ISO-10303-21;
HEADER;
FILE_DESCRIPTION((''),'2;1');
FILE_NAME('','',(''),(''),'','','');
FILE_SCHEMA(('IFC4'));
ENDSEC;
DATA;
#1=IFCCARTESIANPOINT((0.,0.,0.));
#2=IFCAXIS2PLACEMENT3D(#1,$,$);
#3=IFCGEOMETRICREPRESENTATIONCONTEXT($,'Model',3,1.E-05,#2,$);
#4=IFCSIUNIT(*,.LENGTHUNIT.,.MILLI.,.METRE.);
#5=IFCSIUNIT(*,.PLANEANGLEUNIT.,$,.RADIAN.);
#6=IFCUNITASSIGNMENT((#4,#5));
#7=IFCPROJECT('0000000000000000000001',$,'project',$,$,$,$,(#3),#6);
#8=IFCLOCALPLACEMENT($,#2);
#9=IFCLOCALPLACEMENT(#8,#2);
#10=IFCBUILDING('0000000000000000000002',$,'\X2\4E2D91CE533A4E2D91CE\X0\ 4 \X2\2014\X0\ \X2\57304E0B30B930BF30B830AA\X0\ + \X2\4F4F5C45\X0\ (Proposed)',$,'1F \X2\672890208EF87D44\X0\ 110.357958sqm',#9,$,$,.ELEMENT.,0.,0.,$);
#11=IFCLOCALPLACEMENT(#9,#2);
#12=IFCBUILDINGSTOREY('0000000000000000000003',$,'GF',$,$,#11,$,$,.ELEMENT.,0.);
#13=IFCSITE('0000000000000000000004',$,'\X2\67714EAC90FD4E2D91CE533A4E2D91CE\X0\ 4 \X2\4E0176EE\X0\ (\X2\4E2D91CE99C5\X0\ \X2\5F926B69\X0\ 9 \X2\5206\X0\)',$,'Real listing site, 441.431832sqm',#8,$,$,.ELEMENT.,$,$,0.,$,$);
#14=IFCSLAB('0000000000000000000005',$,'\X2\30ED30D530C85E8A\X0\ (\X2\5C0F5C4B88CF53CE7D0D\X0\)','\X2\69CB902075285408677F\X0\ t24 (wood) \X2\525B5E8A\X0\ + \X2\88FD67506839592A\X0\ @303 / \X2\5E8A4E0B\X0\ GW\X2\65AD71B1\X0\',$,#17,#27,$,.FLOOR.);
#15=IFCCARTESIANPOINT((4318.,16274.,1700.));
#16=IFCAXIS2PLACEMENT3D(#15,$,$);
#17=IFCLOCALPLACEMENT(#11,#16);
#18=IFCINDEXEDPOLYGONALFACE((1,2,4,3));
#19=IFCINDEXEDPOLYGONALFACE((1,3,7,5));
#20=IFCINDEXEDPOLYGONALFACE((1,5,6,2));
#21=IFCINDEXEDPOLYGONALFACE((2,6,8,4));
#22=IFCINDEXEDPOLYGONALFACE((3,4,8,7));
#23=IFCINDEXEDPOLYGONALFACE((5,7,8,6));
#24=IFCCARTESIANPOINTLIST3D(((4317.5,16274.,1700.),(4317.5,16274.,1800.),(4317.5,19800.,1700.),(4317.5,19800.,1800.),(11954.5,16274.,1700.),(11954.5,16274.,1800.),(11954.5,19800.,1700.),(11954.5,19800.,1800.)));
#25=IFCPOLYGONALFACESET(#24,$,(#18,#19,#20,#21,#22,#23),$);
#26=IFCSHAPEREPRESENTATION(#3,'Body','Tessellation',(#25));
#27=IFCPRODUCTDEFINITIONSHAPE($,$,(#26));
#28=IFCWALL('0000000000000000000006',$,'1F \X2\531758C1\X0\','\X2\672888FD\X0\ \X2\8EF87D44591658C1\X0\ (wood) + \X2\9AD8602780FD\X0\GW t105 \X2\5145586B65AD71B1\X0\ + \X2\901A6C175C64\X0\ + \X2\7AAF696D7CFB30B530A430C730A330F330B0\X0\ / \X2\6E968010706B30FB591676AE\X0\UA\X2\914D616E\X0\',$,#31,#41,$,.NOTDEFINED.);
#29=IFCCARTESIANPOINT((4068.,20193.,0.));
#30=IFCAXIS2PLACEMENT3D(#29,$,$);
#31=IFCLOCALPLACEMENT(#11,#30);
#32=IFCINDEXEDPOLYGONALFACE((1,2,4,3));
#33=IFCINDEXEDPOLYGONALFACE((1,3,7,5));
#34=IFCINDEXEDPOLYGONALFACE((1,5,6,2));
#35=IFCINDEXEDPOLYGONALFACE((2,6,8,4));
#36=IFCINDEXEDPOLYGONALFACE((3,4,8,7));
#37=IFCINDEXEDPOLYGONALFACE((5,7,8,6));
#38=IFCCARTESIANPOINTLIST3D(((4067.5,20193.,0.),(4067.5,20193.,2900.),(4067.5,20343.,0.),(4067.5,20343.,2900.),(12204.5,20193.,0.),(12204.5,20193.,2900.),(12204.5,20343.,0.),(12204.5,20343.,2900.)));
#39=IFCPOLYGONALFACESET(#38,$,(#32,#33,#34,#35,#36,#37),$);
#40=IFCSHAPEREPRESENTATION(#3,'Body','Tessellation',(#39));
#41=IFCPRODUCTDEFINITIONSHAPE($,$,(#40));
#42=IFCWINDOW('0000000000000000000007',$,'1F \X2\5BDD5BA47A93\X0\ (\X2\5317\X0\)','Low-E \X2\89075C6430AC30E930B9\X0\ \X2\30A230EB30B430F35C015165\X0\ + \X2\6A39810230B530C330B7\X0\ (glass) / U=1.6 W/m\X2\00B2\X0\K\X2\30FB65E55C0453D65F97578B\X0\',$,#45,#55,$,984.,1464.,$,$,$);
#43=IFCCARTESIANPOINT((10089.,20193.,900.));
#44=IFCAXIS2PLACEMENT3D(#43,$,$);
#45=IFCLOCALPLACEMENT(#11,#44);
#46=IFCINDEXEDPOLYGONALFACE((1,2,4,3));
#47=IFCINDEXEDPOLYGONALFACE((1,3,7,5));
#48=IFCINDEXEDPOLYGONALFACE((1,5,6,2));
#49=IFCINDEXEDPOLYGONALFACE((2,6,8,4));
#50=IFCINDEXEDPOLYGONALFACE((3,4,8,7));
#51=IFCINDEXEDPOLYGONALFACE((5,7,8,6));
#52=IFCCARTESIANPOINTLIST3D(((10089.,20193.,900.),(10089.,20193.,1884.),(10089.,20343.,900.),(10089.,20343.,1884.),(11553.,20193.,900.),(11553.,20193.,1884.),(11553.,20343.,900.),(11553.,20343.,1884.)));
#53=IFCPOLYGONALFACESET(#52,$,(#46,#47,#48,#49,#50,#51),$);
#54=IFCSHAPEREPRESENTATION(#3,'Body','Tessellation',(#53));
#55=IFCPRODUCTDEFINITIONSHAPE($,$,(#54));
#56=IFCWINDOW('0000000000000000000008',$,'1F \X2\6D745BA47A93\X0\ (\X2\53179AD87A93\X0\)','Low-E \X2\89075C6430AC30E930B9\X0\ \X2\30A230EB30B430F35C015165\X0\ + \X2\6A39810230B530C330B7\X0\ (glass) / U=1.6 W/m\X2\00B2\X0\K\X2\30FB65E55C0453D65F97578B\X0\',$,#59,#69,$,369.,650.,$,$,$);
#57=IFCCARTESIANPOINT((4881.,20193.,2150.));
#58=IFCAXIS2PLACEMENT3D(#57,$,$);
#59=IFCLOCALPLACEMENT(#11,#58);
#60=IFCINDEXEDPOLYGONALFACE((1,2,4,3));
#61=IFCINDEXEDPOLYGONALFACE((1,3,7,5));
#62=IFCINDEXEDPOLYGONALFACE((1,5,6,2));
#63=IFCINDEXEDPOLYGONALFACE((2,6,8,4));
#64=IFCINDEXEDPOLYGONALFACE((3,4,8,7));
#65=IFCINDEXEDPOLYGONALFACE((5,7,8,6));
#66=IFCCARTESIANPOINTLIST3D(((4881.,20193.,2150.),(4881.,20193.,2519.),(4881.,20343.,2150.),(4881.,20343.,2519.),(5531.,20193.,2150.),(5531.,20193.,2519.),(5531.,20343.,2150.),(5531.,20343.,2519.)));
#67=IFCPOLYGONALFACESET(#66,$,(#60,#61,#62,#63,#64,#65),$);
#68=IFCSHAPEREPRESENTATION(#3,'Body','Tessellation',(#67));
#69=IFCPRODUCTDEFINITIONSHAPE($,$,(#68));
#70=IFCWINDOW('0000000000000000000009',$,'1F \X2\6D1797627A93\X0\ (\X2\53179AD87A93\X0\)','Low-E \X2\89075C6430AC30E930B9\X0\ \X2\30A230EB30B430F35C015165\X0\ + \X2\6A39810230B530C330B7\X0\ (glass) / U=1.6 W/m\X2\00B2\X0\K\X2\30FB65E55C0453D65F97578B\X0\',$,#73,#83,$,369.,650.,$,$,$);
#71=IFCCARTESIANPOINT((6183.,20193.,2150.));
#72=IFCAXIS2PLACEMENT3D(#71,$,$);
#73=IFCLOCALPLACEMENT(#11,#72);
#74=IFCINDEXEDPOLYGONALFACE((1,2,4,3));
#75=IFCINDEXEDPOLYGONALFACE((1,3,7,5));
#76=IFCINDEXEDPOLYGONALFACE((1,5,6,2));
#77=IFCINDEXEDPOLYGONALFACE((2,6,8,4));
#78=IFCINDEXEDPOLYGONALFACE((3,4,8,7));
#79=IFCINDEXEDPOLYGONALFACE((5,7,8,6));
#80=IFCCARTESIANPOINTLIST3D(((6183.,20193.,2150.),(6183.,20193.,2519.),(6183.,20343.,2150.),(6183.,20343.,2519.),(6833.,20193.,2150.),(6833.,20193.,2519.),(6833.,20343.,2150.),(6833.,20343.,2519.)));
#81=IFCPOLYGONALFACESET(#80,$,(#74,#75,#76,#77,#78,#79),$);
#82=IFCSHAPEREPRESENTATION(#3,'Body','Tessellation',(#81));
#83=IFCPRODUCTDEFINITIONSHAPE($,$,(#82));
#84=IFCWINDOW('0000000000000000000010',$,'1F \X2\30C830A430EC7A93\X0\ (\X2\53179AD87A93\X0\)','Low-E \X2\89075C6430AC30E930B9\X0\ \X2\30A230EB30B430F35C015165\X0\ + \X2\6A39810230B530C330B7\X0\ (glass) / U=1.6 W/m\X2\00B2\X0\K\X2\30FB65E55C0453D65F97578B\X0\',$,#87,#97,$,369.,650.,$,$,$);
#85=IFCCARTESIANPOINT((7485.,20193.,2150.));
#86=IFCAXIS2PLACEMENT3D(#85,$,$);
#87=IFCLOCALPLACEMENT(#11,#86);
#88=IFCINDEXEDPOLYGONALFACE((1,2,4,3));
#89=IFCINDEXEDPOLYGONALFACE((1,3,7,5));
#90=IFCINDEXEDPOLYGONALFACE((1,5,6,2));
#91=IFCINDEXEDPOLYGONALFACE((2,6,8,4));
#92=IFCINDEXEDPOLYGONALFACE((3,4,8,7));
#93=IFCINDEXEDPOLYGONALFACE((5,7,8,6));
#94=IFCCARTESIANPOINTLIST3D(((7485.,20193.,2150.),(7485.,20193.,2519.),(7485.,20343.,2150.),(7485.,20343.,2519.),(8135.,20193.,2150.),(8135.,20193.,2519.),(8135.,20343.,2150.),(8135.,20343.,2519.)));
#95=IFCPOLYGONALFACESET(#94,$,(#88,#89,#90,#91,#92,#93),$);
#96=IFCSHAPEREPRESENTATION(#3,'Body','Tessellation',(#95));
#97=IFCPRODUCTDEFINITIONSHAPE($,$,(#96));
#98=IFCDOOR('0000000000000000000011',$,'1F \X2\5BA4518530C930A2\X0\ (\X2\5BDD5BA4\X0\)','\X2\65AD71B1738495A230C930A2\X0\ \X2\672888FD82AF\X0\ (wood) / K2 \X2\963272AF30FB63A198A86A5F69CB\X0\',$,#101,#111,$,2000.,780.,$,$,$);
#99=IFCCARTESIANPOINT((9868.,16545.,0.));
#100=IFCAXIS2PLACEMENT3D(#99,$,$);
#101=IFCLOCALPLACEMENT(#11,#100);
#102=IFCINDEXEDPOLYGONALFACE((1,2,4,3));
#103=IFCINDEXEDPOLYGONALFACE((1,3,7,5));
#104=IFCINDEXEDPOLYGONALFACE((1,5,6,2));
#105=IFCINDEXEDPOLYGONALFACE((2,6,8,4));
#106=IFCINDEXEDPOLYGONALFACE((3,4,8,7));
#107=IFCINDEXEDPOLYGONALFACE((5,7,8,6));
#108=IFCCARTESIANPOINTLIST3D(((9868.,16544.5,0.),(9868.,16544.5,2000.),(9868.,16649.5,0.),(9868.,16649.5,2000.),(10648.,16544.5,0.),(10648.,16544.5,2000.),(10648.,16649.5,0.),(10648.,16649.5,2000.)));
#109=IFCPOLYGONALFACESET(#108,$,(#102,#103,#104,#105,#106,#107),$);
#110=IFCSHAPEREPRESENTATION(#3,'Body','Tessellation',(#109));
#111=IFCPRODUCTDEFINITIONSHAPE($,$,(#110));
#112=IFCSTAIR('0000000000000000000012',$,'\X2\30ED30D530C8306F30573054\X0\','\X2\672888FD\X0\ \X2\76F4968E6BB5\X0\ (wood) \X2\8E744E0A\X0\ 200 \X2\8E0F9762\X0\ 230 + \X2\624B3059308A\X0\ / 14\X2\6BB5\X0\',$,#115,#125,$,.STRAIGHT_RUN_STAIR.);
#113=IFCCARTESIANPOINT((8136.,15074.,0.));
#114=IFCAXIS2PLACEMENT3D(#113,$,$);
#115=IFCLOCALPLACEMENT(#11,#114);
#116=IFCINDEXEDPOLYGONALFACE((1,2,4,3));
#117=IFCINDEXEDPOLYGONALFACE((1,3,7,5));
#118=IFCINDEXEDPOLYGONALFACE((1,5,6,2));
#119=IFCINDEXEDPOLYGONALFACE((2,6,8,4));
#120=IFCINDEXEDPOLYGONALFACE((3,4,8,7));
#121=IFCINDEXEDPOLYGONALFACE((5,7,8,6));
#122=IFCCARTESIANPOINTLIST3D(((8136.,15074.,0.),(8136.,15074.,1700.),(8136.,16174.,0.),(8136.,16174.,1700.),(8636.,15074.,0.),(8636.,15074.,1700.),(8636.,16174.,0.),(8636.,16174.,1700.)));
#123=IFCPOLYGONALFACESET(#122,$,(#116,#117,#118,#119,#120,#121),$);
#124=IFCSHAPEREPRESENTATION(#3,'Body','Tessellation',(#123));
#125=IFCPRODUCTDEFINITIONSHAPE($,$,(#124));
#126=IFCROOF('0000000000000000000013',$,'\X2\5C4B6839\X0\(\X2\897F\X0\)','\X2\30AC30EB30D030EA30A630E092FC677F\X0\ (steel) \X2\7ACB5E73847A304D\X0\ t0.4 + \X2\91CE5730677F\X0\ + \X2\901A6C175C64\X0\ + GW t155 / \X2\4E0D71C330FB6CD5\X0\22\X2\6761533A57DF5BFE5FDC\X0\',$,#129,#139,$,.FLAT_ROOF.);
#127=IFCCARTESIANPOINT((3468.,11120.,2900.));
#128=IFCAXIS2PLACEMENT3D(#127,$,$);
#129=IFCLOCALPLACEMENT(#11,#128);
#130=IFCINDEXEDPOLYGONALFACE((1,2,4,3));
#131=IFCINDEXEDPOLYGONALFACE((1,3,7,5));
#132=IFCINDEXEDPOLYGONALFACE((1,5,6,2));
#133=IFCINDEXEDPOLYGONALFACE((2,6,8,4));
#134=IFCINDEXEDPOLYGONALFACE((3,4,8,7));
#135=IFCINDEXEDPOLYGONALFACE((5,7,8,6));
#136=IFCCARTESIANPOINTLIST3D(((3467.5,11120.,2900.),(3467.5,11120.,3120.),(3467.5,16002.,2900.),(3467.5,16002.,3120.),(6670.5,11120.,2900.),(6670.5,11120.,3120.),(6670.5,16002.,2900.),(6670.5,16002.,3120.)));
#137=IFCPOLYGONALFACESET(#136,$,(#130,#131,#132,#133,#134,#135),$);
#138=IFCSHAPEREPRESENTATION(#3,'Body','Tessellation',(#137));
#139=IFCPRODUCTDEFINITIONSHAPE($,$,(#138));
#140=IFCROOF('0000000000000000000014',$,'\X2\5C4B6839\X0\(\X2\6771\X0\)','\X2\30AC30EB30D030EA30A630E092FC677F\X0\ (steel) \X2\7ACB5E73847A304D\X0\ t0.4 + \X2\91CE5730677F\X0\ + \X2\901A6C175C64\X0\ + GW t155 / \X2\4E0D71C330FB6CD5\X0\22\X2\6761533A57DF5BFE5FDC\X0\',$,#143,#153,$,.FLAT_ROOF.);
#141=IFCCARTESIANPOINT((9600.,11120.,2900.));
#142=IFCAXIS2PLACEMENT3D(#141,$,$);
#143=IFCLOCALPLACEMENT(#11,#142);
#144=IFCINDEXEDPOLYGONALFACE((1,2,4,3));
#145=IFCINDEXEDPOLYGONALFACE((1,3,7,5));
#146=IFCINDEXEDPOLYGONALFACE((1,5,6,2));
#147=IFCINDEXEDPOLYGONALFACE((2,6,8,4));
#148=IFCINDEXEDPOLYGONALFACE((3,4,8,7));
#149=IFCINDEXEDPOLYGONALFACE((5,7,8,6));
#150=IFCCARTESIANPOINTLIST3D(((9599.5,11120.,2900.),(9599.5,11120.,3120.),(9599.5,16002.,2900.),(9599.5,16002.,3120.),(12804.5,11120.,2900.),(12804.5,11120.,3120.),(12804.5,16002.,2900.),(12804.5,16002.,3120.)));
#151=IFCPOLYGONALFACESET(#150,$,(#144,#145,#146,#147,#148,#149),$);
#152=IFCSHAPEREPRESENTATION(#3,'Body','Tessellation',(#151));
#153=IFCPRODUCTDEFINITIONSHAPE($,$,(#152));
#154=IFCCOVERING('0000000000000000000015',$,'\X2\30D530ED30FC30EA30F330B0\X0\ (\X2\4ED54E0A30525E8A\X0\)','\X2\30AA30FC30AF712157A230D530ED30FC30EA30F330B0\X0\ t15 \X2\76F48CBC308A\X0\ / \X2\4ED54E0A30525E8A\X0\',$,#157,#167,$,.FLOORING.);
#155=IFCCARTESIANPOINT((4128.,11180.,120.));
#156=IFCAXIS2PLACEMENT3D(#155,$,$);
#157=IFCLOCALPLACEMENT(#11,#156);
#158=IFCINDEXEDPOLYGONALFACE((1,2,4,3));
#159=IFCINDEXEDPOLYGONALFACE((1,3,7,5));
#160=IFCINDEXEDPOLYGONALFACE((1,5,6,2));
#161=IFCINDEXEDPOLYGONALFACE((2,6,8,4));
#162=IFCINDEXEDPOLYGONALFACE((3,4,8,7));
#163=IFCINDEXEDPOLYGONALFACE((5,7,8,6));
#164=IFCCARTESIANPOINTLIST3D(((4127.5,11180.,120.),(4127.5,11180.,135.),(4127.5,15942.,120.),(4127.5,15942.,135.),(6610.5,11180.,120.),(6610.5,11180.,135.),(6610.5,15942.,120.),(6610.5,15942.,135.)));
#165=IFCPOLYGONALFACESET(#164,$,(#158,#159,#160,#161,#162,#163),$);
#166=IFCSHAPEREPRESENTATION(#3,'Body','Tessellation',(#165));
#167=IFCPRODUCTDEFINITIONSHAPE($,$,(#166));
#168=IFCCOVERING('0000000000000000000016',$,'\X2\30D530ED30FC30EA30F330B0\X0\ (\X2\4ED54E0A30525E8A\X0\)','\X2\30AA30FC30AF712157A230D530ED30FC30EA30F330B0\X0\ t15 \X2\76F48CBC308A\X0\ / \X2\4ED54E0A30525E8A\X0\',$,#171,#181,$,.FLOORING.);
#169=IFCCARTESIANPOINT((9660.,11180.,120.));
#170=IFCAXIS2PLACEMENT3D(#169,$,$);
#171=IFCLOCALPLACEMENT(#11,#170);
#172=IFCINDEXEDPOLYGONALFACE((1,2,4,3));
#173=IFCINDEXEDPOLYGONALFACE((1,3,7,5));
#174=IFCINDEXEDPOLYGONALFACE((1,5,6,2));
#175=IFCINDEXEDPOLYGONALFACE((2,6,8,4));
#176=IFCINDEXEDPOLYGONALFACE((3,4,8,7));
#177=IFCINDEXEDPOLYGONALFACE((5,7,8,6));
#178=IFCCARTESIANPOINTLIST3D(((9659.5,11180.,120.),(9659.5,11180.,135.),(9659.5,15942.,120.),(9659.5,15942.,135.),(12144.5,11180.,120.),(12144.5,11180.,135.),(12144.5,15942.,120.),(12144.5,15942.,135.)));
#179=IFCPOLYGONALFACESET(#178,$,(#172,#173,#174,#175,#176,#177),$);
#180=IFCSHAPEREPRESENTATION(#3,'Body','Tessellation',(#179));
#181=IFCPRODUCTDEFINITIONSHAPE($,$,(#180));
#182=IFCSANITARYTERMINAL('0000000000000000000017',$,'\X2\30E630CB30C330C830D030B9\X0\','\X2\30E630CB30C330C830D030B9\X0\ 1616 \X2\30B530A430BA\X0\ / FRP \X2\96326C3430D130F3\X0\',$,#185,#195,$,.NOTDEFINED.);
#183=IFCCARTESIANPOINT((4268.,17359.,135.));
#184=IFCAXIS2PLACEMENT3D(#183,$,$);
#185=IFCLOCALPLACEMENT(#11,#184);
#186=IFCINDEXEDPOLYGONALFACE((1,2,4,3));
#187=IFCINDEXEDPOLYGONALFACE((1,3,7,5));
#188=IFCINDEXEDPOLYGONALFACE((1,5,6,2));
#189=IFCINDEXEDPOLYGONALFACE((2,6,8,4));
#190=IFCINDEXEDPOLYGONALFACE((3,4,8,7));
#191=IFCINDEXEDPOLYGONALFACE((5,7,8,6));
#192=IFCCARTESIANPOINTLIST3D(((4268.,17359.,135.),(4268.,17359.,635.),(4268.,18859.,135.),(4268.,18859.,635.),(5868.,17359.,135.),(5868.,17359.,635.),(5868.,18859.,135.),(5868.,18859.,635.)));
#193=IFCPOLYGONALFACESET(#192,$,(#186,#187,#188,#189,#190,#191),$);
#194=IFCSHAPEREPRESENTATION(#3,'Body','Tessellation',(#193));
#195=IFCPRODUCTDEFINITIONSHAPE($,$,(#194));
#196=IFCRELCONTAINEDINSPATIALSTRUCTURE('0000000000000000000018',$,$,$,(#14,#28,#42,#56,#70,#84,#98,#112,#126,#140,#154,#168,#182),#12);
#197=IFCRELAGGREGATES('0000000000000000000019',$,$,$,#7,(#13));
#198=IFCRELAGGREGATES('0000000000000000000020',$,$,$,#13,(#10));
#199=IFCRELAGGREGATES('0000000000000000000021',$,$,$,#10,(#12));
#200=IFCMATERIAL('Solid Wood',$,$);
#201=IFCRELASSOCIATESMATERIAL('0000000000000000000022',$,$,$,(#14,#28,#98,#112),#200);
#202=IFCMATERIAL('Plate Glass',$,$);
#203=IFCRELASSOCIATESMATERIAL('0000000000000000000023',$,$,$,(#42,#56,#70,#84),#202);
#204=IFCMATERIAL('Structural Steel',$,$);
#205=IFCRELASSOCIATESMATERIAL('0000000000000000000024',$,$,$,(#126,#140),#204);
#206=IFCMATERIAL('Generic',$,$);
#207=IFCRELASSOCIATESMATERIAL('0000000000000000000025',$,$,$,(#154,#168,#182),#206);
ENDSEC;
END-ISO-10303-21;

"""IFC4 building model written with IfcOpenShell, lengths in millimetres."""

from ifc_helpers import new_model, si_unit, frame, frame_2d, origin, place, context, project, spatial, rectangle, extrude, material, element, fill, save


model = new_model("IFC4")

# Units and contexts
model_context = context("Model", 3, precision=1e-05, world=origin())
ifc_project = project(units=[si_unit("LENGTHUNIT", "METRE", prefix="MILLI"), si_unit("PLANEANGLEUNIT", "RADIAN")], contexts=[model_context])

# Site, building, storey
site_placement = place(None, origin())
site = spatial("IfcSite", under=ifc_project, at=site_placement, Name="東京都中野区中野 4 丁目 (中野駅 徒歩 9 分)", ObjectType="Real listing site, 441.431832sqm", CompositionType="ELEMENT", RefElevation=0.0)
building_placement = place(site_placement, origin())
building = spatial("IfcBuilding", under=site, at=building_placement, Name="中野区中野 4 — 地下スタジオ + 住居 (Proposed)", ObjectType="1F 木造軸組 110.357958sqm", CompositionType="ELEMENT", ElevationOfRefHeight=0.0, ElevationOfTerrain=0.0)
storey_placement = place(building_placement, origin())
storey = spatial("IfcBuildingStorey", under=building, at=storey_placement, Name="GF", CompositionType="ELEMENT", Elevation=0.0)

# Slab
ifc_material_1 = material(Name="Solid Wood")
slab_1_placement = place(storey_placement, frame((4318.0, 16274.0, 1700.0)))
element("IfcSlab", 1, at=slab_1_placement, inside=storey, material=ifc_material_1, Name="ロフト床 (小屋裏収納)", Description="構造用合板 t24 (wood) 剛床 + 製材根太 @303 / 床下 GW断熱", PredefinedType="FLOOR", context=model_context, shape_type="SweptSolid", body=[
    extrude(rectangle(XDim=7637.0, YDim=3526.0, at=frame_2d((3818.0, 1763.0))), frame((4318.0, 16274.0, 1700.0)), (0.0, 0.0, 1.0), 100.0),
])

# Wall, openings, windows
wall_1_placement = place(storey_placement, frame((4068.0, 20193.0, 0.0)))
wall_1 = element("IfcWall", 2, at=wall_1_placement, inside=storey, material=ifc_material_1, Name="1F 北壁", Description="木製 軸組外壁 (wood) + 高性能GW t105 充填断熱 + 通気層 + 窯業系サイディング / 準耐火・外皮UA配慮", PredefinedType="NOTDEFINED", context=model_context, shape_type="SweptSolid", body=[
    extrude(rectangle(XDim=8137.0, YDim=150.0, at=frame_2d((4068.0, 75.0))), frame((4068.0, 20193.0, 0.0)), (0.0, 0.0, 1.0), 2900.0),
])
opening_1_placement = place(storey_placement, frame((10089.0, 20193.0, 900.0)))
opening_1 = element("IfcOpeningElement", 3, at=opening_1_placement, cuts=wall_1, PredefinedType="NOTDEFINED", context=model_context, shape_type="SweptSolid", body=[
    extrude(rectangle(XDim=1464.0, YDim=150.0, at=frame_2d((732.0, 75.0))), frame((10089.0, 20193.0, 900.0)), (0.0, 0.0, 1.0), 984.0),
])
opening_2_placement = place(storey_placement, frame((4881.0, 20193.0, 2150.0)))
opening_2 = element("IfcOpeningElement", 4, at=opening_2_placement, cuts=wall_1, PredefinedType="NOTDEFINED", context=model_context, shape_type="SweptSolid", body=[
    extrude(rectangle(XDim=650.0, YDim=150.0, at=frame_2d((325.0, 75.0))), frame((4881.0, 20193.0, 2150.0)), (0.0, 0.0, 1.0), 369.0),
])
opening_3_placement = place(storey_placement, frame((6183.0, 20193.0, 2150.0)))
opening_3 = element("IfcOpeningElement", 5, at=opening_3_placement, cuts=wall_1, PredefinedType="NOTDEFINED", context=model_context, shape_type="SweptSolid", body=[
    extrude(rectangle(XDim=650.0, YDim=150.0, at=frame_2d((325.0, 75.0))), frame((6183.0, 20193.0, 2150.0)), (0.0, 0.0, 1.0), 369.0),
])
opening_4_placement = place(storey_placement, frame((7485.0, 20193.0, 2150.0)))
opening_4 = element("IfcOpeningElement", 6, at=opening_4_placement, cuts=wall_1, PredefinedType="NOTDEFINED", context=model_context, shape_type="SweptSolid", body=[
    extrude(rectangle(XDim=650.0, YDim=150.0, at=frame_2d((325.0, 75.0))), frame((7485.0, 20193.0, 2150.0)), (0.0, 0.0, 1.0), 369.0),
])
ifc_material_2 = material(Name="Plate Glass")
window_1_placement = place(storey_placement, frame((10089.0, 20193.0, 900.0)))
window_1 = element("IfcWindow", 7, at=window_1_placement, inside=storey, material=ifc_material_2, Name="1F 寝室窓 (北)", Description="Low-E 複層ガラス アルゴン封入 + 樹脂サッシ (glass) / U=1.6 W/m²K・日射取得型", OverallHeight=984.0, OverallWidth=1464.0, context=model_context, shape_type="SweptSolid", body=[
    extrude(rectangle(XDim=1464.0, YDim=150.0, at=frame_2d((732.0, 75.0))), frame((10089.0, 20193.0, 900.0)), (0.0, 0.0, 1.0), 984.0),
])
fill(opening_1, window_1)
window_2_placement = place(storey_placement, frame((4881.0, 20193.0, 2150.0)))
window_2 = element("IfcWindow", 8, at=window_2_placement, inside=storey, material=ifc_material_2, Name="1F 浴室窓 (北高窓)", Description="Low-E 複層ガラス アルゴン封入 + 樹脂サッシ (glass) / U=1.6 W/m²K・日射取得型", OverallHeight=369.0, OverallWidth=650.0, context=model_context, shape_type="SweptSolid", body=[
    extrude(rectangle(XDim=650.0, YDim=150.0, at=frame_2d((325.0, 75.0))), frame((4881.0, 20193.0, 2150.0)), (0.0, 0.0, 1.0), 369.0),
])
fill(opening_2, window_2)
window_3_placement = place(storey_placement, frame((6183.0, 20193.0, 2150.0)))
window_3 = element("IfcWindow", 9, at=window_3_placement, inside=storey, material=ifc_material_2, Name="1F 洗面窓 (北高窓)", Description="Low-E 複層ガラス アルゴン封入 + 樹脂サッシ (glass) / U=1.6 W/m²K・日射取得型", OverallHeight=369.0, OverallWidth=650.0, context=model_context, shape_type="SweptSolid", body=[
    extrude(rectangle(XDim=650.0, YDim=150.0, at=frame_2d((325.0, 75.0))), frame((6183.0, 20193.0, 2150.0)), (0.0, 0.0, 1.0), 369.0),
])
fill(opening_3, window_3)
window_4_placement = place(storey_placement, frame((7485.0, 20193.0, 2150.0)))
window_4 = element("IfcWindow", 10, at=window_4_placement, inside=storey, material=ifc_material_2, Name="1F トイレ窓 (北高窓)", Description="Low-E 複層ガラス アルゴン封入 + 樹脂サッシ (glass) / U=1.6 W/m²K・日射取得型", OverallHeight=369.0, OverallWidth=650.0, context=model_context, shape_type="SweptSolid", body=[
    extrude(rectangle(XDim=650.0, YDim=150.0, at=frame_2d((325.0, 75.0))), frame((7485.0, 20193.0, 2150.0)), (0.0, 0.0, 1.0), 369.0),
])
fill(opening_4, window_4)

# Door
door_1_placement = place(storey_placement, frame((9868.0, 16545.0, 0.0)))
element("IfcDoor", 11, at=door_1_placement, inside=storey, material=ifc_material_1, Name="1F 室内ドア (寝室)", Description="断熱玄関ドア 木製芯 (wood) / K2 防犯・採風機構", OverallHeight=2000.0, OverallWidth=780.0, context=model_context, shape_type="SweptSolid", body=[
    extrude(rectangle(XDim=780.0, YDim=105.0, at=frame_2d((390.0, 52.0))), frame((9868.0, 16545.0, 0.0)), (0.0, 0.0, 1.0), 2000.0),
])

# Stair
stair_placement = place(storey_placement, frame((8136.0, 15074.0, 0.0)))
element("IfcStair", 12, at=stair_placement, inside=storey, material=ifc_material_1, Name="ロフトはしご", Description="木製 直階段 (wood) 蹴上 200 踏面 230 + 手すり / 14段", PredefinedType="STRAIGHT_RUN_STAIR", context=model_context, shape_type="SweptSolid", body=[
    extrude(rectangle(XDim=500.0, YDim=1100.0, at=frame_2d((250.0, 550.0))), frame((8136.0, 15074.0, 0.0)), (0.0, 0.0, 1.0), 1700.0),
])

# Roofs
ifc_material_3 = material(Name="Structural Steel")
roof_1_placement = place(storey_placement, frame((3468.0, 11120.0, 2900.0)))
element("IfcRoof", 13, at=roof_1_placement, inside=storey, material=ifc_material_3, Name="屋根(西)", Description="ガルバリウム鋼板 (steel) 立平葺き t0.4 + 野地板 + 通気層 + GW t155 / 不燃・法22条区域対応", PredefinedType="FLAT_ROOF", context=model_context, shape_type="SweptSolid", body=[
    extrude(rectangle(XDim=3203.0, YDim=4882.0, at=frame_2d((1601.0, 2441.0))), frame((3468.0, 11120.0, 2900.0)), (0.0, 0.0, 1.0), 220.0),
])
roof_2_placement = place(storey_placement, frame((9600.0, 11120.0, 2900.0)))
element("IfcRoof", 14, at=roof_2_placement, inside=storey, material=ifc_material_3, Name="屋根(東)", Description="ガルバリウム鋼板 (steel) 立平葺き t0.4 + 野地板 + 通気層 + GW t155 / 不燃・法22条区域対応", PredefinedType="FLAT_ROOF", context=model_context, shape_type="SweptSolid", body=[
    extrude(rectangle(XDim=3205.0, YDim=4882.0, at=frame_2d((1602.0, 2441.0))), frame((9600.0, 11120.0, 2900.0)), (0.0, 0.0, 1.0), 220.0),
])

# Coverings
ifc_material_4 = material(Name="Generic")
covering_1_placement = place(storey_placement, frame((4128.0, 11180.0, 120.0)))
element("IfcCovering", 15, at=covering_1_placement, inside=storey, material=ifc_material_4, Name="フローリング (仕上げ床)", Description="オーク無垢フローリング t15 直貼り / 仕上げ床", PredefinedType="FLOORING", context=model_context, shape_type="SweptSolid", body=[
    extrude(rectangle(XDim=2483.0, YDim=4762.0, at=frame_2d((1241.0, 2381.0))), frame((4128.0, 11180.0, 120.0)), (0.0, 0.0, 1.0), 15.0),
])
covering_2_placement = place(storey_placement, frame((9660.0, 11180.0, 120.0)))
element("IfcCovering", 16, at=covering_2_placement, inside=storey, material=ifc_material_4, Name="フローリング (仕上げ床)", Description="オーク無垢フローリング t15 直貼り / 仕上げ床", PredefinedType="FLOORING", context=model_context, shape_type="SweptSolid", body=[
    extrude(rectangle(XDim=2485.0, YDim=4762.0, at=frame_2d((1242.0, 2381.0))), frame((9660.0, 11180.0, 120.0)), (0.0, 0.0, 1.0), 15.0),
])

# Sanitary terminal
sanitary_terminal_1_placement = place(storey_placement, frame((4268.0, 17359.0, 135.0)))
element("IfcSanitaryTerminal", 17, at=sanitary_terminal_1_placement, inside=storey, material=ifc_material_4, Name="ユニットバス", Description="ユニットバス 1616 サイズ / FRP 防水パン", PredefinedType="NOTDEFINED", context=model_context, shape_type="SweptSolid", body=[
    extrude(rectangle(XDim=1600.0, YDim=1500.0, at=frame_2d((800.0, 750.0))), frame((4268.0, 17359.0, 135.0)), (0.0, 0.0, 1.0), 500.0),
])

save(model, "model.ifc")
